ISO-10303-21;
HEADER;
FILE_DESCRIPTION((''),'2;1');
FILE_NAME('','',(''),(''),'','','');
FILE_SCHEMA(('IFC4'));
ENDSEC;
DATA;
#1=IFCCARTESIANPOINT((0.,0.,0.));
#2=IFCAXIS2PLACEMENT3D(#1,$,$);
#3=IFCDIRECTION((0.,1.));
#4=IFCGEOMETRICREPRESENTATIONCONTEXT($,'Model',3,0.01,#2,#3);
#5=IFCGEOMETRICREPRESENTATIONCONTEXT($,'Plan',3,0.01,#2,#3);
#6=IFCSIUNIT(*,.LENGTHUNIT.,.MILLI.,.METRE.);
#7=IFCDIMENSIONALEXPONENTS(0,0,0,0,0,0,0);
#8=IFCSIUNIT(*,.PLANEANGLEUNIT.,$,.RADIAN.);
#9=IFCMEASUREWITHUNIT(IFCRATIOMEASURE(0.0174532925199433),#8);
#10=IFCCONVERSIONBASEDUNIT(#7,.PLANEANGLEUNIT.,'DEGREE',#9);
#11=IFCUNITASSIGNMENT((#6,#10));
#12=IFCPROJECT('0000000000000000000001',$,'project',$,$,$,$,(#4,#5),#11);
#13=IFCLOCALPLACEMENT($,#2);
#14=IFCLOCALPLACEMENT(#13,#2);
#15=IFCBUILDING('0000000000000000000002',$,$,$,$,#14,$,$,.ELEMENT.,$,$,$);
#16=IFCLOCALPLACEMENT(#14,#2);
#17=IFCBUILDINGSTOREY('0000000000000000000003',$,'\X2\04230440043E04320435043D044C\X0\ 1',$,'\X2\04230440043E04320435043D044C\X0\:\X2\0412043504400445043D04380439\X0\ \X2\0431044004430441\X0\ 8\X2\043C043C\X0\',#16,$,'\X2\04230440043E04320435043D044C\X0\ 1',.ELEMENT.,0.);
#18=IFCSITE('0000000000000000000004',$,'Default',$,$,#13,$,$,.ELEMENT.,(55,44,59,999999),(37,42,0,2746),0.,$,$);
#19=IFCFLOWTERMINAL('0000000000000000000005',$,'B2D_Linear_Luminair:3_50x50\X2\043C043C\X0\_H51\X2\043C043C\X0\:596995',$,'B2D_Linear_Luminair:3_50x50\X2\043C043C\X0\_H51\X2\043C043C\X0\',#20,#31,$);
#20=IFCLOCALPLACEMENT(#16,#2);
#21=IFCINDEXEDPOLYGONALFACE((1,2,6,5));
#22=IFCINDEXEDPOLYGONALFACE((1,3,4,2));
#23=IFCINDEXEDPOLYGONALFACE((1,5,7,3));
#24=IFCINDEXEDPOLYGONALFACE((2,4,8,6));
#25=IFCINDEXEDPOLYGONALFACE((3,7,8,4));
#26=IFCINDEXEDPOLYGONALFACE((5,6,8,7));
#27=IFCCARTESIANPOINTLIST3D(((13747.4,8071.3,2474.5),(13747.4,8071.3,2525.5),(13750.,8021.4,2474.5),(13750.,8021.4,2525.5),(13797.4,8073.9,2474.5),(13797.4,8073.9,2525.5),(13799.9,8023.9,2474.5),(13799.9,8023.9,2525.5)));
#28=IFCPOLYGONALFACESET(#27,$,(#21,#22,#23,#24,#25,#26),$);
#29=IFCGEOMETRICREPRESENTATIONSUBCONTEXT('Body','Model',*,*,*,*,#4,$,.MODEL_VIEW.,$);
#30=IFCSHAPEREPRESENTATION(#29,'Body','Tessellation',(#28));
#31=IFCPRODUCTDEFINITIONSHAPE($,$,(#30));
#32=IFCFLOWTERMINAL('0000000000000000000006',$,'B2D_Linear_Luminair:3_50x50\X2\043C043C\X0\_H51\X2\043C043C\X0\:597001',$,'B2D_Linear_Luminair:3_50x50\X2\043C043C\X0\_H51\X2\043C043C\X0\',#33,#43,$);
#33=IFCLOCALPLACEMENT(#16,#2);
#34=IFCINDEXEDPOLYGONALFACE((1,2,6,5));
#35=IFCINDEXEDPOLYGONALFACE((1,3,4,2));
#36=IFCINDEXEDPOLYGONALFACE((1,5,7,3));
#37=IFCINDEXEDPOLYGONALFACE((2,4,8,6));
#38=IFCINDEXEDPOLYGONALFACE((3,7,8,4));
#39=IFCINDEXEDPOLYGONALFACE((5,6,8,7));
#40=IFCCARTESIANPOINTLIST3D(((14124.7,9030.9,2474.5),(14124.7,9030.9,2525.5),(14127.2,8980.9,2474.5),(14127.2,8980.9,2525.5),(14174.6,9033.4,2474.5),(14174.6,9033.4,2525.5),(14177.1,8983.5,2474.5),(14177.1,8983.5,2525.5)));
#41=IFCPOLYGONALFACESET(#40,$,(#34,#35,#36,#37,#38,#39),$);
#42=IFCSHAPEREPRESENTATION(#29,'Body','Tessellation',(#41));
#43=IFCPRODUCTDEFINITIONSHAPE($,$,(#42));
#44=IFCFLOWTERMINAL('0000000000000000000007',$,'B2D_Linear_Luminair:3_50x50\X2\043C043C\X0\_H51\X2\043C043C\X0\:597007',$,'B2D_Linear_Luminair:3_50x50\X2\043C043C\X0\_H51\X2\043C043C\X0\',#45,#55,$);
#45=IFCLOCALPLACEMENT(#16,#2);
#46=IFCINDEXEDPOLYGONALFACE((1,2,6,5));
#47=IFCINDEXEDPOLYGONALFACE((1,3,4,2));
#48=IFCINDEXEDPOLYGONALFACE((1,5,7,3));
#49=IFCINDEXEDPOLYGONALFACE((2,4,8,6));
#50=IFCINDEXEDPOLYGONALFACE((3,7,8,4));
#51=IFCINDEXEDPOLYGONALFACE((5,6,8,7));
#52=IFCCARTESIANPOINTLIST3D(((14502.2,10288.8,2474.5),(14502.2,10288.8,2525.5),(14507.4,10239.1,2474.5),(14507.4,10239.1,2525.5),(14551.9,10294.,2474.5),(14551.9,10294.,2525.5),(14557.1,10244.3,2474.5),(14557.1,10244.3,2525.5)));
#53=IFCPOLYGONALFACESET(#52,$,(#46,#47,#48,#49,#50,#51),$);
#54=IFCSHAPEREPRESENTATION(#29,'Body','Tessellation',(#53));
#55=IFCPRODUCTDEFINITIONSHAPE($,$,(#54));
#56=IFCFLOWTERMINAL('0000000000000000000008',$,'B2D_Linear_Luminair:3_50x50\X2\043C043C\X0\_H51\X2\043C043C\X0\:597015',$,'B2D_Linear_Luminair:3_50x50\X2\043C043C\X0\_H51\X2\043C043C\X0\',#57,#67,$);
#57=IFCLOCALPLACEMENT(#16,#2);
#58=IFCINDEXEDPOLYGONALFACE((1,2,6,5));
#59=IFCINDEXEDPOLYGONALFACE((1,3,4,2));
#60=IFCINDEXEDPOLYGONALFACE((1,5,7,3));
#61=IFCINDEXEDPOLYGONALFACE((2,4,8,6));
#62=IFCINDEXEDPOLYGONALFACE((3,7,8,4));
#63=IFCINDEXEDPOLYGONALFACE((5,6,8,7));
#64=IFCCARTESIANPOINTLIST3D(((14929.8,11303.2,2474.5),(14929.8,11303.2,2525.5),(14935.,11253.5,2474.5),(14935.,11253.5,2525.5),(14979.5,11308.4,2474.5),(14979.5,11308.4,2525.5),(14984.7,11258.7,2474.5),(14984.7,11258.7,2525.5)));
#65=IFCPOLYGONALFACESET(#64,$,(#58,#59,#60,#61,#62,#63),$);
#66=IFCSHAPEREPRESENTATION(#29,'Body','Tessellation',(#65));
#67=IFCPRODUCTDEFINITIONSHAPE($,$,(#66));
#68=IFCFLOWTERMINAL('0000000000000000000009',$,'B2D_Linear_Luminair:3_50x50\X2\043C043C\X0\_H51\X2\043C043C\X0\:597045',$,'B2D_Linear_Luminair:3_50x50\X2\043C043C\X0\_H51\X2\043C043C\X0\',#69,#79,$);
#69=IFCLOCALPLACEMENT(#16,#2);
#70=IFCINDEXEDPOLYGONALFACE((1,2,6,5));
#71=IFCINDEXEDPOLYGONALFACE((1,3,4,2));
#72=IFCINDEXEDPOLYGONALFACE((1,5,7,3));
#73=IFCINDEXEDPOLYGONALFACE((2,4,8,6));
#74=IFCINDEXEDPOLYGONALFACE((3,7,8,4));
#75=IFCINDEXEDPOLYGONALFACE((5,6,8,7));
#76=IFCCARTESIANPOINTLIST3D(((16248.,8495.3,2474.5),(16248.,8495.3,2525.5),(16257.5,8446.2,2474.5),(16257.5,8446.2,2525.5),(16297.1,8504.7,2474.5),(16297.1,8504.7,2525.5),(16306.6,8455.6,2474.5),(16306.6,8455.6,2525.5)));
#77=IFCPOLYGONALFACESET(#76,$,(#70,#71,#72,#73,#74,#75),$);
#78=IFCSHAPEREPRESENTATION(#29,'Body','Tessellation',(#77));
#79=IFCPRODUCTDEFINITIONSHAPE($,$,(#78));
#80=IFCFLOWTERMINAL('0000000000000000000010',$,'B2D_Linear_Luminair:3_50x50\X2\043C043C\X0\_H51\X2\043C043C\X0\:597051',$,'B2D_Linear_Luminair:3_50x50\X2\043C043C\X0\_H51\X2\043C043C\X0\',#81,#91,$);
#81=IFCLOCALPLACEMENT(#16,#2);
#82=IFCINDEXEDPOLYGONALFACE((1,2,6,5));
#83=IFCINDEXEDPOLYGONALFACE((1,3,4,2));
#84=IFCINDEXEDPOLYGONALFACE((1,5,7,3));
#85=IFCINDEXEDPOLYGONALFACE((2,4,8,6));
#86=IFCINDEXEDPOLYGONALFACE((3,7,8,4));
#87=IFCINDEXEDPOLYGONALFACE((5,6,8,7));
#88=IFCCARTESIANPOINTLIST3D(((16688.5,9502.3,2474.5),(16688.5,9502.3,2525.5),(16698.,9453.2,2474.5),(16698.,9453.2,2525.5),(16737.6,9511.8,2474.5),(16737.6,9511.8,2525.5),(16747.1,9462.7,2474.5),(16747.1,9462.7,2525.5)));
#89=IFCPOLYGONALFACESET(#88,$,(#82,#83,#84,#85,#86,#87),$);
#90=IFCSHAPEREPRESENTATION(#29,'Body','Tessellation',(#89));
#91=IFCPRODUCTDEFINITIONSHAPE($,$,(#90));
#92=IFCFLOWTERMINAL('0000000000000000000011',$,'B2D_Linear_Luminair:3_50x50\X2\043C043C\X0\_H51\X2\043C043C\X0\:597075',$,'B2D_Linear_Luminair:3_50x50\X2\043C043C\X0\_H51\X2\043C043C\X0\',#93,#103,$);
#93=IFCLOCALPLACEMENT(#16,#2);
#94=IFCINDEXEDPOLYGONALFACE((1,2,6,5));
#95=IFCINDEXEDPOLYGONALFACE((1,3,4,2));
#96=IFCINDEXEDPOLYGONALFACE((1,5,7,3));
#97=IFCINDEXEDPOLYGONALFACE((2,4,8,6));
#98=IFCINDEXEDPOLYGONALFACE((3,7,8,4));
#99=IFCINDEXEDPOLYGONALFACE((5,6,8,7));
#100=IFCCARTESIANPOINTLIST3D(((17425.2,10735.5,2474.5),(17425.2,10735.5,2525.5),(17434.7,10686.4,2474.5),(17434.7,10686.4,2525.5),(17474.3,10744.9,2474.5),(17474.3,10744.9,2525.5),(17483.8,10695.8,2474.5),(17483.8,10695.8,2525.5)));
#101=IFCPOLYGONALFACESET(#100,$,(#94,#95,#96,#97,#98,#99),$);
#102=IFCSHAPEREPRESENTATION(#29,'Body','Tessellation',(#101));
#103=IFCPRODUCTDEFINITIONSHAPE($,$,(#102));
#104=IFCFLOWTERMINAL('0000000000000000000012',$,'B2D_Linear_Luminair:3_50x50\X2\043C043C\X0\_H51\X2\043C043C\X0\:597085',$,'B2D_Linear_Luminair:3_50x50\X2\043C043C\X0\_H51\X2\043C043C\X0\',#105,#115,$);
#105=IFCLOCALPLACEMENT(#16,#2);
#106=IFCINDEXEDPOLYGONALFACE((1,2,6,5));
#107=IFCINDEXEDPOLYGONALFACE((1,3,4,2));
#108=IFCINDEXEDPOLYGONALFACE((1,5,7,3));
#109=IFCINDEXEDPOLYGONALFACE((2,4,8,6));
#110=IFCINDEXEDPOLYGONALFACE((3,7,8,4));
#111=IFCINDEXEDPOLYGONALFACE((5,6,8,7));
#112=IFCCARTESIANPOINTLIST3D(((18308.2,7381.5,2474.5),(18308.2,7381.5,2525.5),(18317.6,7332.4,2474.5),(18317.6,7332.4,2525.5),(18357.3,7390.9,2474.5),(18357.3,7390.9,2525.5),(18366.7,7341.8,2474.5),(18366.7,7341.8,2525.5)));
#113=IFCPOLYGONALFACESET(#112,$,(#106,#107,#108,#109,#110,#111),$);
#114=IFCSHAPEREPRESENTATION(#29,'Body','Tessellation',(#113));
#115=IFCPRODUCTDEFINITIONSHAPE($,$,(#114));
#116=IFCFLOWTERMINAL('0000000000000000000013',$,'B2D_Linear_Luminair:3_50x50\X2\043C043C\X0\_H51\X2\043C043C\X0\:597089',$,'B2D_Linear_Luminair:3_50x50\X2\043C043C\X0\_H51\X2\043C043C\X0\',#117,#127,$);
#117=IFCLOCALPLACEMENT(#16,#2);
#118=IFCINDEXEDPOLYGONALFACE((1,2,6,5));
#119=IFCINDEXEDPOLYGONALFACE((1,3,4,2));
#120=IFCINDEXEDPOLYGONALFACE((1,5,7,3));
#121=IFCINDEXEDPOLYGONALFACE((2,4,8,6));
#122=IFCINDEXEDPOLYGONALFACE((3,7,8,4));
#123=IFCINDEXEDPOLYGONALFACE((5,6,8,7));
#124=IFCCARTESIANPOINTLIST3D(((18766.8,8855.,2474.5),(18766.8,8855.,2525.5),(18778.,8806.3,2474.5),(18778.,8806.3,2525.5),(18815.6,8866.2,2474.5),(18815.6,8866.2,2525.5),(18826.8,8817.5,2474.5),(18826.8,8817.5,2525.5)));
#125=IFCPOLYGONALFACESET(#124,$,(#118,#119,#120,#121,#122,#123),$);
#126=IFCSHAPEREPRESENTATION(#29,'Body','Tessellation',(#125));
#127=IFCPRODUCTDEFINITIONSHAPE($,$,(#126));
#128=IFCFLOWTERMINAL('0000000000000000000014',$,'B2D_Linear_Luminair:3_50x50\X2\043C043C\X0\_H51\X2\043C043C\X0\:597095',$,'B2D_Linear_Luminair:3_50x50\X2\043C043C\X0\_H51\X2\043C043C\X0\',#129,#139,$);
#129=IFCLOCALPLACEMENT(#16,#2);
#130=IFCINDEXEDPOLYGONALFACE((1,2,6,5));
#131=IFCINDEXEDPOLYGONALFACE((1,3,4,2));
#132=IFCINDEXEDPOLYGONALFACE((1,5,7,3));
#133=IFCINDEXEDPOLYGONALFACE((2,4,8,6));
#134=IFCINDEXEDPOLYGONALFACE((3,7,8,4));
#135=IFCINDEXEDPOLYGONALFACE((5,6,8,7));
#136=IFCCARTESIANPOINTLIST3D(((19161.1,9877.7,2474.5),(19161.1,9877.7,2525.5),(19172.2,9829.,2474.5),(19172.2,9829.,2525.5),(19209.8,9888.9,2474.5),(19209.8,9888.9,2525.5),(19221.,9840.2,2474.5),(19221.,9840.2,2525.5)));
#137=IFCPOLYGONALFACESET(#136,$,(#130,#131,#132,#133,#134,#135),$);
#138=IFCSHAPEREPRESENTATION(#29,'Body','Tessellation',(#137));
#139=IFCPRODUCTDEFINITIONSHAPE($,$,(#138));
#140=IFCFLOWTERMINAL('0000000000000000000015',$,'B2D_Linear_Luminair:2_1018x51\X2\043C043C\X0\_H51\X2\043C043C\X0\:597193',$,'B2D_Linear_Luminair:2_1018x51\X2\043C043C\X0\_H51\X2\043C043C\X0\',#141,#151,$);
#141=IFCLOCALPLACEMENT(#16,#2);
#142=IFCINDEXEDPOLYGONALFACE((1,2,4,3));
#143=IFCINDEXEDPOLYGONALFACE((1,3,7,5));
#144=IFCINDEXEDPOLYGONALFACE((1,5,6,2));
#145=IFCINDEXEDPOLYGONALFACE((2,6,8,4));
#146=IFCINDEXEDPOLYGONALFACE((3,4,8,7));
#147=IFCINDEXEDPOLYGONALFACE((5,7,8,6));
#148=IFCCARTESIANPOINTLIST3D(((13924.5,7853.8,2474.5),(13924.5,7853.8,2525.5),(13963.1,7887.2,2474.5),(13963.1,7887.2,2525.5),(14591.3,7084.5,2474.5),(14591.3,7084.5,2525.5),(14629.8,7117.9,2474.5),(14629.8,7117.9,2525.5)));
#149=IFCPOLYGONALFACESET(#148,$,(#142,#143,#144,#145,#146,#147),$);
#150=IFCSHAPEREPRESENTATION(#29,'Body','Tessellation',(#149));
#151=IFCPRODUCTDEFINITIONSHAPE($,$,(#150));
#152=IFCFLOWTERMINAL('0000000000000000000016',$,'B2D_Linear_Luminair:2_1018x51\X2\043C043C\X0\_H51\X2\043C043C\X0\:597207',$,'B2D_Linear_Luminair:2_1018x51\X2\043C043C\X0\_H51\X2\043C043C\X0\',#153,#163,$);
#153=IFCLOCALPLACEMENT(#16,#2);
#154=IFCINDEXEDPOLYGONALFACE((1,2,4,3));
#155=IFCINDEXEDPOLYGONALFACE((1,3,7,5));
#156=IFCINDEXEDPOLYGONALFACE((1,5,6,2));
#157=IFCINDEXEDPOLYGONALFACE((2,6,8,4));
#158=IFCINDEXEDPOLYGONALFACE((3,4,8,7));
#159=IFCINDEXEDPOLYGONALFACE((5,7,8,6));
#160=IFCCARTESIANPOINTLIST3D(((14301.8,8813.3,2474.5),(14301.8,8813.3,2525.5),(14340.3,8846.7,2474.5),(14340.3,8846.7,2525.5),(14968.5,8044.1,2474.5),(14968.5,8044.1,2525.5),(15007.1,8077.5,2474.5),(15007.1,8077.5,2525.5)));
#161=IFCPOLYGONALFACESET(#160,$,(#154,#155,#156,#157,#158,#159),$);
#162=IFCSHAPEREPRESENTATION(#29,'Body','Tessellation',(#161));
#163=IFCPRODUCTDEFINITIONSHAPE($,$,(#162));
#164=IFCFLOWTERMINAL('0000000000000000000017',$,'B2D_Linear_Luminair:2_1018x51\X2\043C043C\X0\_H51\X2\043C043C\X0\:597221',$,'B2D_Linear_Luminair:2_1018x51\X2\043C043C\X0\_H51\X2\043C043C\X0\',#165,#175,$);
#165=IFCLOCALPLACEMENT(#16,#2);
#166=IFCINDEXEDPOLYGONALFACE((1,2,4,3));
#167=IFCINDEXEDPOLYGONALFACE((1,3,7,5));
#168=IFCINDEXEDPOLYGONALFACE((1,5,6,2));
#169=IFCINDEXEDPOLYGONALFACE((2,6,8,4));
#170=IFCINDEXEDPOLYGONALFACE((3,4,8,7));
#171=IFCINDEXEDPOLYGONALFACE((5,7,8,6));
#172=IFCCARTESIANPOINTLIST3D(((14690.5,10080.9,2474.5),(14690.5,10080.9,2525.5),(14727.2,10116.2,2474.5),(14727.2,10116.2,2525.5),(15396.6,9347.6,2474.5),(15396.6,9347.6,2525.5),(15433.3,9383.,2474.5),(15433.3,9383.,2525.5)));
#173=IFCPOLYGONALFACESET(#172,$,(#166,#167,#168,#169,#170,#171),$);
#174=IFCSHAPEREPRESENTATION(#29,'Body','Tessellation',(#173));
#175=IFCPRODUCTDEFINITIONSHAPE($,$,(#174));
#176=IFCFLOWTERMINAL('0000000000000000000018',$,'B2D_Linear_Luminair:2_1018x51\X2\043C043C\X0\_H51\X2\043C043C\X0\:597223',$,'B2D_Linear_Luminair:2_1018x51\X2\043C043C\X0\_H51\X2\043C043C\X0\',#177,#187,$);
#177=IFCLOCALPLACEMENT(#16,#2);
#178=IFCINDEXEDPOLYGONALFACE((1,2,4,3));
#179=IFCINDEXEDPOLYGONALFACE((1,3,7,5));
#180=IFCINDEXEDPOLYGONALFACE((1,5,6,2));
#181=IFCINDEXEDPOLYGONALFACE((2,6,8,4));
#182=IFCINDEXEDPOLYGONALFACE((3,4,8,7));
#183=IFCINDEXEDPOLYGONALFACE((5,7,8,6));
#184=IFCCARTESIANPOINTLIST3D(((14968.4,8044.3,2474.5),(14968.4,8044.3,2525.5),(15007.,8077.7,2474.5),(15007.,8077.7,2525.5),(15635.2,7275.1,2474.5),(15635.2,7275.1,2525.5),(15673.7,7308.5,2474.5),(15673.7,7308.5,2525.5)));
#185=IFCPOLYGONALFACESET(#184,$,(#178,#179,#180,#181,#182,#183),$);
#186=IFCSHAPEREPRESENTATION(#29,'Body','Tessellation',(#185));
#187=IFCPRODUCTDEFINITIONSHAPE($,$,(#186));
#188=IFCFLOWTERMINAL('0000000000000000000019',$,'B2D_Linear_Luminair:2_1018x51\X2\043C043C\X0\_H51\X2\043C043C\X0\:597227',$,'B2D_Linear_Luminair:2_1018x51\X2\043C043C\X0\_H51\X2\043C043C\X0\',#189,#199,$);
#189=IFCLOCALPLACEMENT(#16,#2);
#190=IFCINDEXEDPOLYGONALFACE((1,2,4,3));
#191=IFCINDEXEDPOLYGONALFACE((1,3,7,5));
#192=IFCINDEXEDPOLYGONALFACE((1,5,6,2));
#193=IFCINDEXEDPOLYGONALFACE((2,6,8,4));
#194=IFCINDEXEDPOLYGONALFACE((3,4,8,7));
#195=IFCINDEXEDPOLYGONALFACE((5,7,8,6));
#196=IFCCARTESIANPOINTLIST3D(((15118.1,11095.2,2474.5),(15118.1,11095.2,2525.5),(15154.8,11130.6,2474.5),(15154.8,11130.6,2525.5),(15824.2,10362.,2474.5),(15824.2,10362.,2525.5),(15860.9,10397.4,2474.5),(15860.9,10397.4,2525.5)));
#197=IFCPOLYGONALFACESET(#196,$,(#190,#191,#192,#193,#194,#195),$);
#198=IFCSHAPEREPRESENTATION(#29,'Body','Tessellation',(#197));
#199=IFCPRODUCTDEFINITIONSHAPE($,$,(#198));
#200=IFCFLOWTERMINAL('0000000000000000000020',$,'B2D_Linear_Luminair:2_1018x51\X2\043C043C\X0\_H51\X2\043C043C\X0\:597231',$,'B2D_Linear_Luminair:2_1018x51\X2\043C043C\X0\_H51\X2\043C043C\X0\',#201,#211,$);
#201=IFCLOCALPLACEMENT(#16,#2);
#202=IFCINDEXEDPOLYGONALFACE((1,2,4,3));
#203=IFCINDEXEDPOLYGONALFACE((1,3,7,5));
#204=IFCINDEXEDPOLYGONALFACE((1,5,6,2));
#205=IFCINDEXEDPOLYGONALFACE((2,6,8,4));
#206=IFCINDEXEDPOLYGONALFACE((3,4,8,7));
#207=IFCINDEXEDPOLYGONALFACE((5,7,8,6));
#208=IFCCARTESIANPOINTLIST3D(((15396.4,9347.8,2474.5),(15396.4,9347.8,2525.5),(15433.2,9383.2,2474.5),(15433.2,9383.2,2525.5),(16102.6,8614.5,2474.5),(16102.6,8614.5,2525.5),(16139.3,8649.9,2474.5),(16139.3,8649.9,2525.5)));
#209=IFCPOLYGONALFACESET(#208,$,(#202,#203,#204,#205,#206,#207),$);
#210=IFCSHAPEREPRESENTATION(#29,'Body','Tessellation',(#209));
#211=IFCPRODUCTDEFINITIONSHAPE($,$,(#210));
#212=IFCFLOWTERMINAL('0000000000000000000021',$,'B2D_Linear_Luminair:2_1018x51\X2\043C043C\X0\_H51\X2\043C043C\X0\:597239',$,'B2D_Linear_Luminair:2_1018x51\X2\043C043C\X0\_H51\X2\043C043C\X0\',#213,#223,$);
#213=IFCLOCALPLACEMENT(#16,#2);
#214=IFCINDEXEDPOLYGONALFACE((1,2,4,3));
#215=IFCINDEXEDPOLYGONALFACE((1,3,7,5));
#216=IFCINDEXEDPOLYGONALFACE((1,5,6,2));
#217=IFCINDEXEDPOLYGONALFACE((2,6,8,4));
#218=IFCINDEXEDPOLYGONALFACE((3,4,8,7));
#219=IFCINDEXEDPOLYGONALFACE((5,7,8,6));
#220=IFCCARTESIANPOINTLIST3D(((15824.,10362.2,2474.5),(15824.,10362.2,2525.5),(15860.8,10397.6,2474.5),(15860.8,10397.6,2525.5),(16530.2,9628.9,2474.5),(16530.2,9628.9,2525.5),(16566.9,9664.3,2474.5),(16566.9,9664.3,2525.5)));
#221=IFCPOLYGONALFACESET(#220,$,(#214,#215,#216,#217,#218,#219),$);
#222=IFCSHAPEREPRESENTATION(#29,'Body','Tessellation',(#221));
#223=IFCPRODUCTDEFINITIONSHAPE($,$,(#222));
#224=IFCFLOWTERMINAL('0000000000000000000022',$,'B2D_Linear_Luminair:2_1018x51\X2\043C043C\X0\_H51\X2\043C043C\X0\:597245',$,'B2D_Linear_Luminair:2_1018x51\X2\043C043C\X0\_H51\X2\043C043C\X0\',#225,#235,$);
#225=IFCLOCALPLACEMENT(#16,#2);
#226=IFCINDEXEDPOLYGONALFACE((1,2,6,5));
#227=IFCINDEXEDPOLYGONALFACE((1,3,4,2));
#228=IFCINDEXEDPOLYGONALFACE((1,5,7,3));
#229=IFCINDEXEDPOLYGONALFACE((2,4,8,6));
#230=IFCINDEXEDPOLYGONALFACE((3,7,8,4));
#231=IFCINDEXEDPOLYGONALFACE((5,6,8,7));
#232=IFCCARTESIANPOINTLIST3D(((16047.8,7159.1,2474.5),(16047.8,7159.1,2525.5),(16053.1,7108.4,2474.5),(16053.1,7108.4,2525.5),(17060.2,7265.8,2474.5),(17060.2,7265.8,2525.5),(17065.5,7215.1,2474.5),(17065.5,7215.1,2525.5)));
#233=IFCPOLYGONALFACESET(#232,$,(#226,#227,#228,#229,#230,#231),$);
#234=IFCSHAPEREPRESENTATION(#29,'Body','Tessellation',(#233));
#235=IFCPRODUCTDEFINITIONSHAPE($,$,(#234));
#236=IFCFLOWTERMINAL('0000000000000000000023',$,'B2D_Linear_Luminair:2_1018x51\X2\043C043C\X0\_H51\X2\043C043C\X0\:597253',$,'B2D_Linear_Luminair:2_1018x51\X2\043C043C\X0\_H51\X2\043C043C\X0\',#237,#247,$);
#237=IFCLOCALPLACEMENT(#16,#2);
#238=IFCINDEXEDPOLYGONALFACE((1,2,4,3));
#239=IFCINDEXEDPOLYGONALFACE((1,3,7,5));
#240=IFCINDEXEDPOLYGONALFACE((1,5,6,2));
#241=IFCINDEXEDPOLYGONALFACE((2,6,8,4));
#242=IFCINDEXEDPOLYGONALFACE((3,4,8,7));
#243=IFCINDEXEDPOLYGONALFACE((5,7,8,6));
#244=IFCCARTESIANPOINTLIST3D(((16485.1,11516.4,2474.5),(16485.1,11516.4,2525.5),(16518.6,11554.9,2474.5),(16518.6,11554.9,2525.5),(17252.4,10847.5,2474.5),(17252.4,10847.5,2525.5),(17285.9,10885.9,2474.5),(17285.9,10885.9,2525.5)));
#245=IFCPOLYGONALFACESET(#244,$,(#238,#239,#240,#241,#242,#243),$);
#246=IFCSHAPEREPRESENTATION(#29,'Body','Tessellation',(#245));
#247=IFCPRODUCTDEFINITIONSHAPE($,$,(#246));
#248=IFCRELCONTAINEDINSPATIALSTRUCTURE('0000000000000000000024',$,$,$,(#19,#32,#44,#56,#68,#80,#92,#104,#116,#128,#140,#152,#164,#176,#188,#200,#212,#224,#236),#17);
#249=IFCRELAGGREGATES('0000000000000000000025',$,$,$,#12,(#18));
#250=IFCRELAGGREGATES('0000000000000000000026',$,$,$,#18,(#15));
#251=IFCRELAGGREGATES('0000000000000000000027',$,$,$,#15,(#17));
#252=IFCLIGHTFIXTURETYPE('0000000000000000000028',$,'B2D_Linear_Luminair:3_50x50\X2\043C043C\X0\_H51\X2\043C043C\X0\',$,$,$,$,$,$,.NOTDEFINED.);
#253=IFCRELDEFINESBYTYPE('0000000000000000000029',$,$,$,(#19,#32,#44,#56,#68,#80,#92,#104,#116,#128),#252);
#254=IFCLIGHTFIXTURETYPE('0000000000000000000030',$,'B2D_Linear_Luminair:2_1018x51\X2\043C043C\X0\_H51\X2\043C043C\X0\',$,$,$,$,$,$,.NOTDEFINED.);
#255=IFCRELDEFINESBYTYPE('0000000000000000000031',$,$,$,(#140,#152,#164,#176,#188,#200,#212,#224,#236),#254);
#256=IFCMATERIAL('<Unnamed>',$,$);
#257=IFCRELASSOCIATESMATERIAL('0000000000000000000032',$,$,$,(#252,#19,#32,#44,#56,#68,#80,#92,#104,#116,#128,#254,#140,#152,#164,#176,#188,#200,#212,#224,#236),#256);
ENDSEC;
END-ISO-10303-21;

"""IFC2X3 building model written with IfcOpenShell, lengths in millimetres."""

from ifc_helpers import new_model, entity, si_unit, converted_unit, direction, frame, origin, origin_2d_with_axis, place, context, subcontext, project, spatial, rectangle, extrude, source, transform, mapped, material, type_object, type_shapes, element, save


model = new_model("IFC2X3")

# Units and contexts
model_context = context("Model", 3, precision=0.01, world=origin(), true_north=direction((0.0, 1.0)))
plan_context = context("Plan", 3, precision=0.01, world=origin(), true_north=direction((0.0, 1.0)))
body_context = subcontext(model_context, "Body", "Model", "MODEL_VIEW")
ifc_project = project(units=[si_unit("LENGTHUNIT", "METRE", prefix="MILLI"), converted_unit("PLANEANGLEUNIT", "DEGREE", entity("IfcRatioMeasure", 0.0174532925199433), si_unit("PLANEANGLEUNIT", "RADIAN"), dimensions=[0, 0, 0, 0, 0, 0, 0])], contexts=[model_context, plan_context])

# Site, building, storey
site_placement = place(None, origin())
site = spatial("IfcSite", under=ifc_project, at=site_placement, Name="Default", CompositionType="ELEMENT", RefLatitude=(55, 44, 59, 999999), RefLongitude=(37, 42, 0, 2746), RefElevation=0.0)
building_placement = place(site_placement, origin())
building = spatial("IfcBuilding", under=site, at=building_placement, CompositionType="ELEMENT")
storey_placement = place(building_placement, origin())
storey = spatial("IfcBuildingStorey", under=building, at=storey_placement, Name="Уровень 1", ObjectType="Уровень:Верхний брус 8мм", LongName="Уровень 1", CompositionType="ELEMENT", Elevation=0.0)

# Flow terminals
ifc_material = material(Name="<Unnamed>")
light_fixture_type_1 = type_object("IfcLightFixtureType", Name="B2D_Linear_Luminair:3_50x50мм_H51мм", PredefinedType="NOTDEFINED", material=ifc_material)
shared_shape_1 = source(origin(), body_context, "Body", "SweptSolid", [
    extrude(rectangle(XDim=50.0, YDim=50.0, at=origin_2d_with_axis()), frame((0.0, 0.0, 0.0), z_axis=(0.0, 0.0, 1.0), x_axis=(-1.0, 0.0, 0.0)), (0.0, 0.0, 1.0), 51.0),
])
type_shapes(light_fixture_type_1, [shared_shape_1])
for number, where, z_axis, x_axis, name in (
    (1, (13773.7, 8047.6, 2525.5), (0.0, 0.0, -1.0), (0.998702, 0.050942, 0.0), "B2D_Linear_Luminair:3_50x50мм_H51мм:596995"),
    (2, (14150.9, 9007.2, 2525.5), (0.0, 0.0, -1.0), (0.998702, 0.050942, 0.0), "B2D_Linear_Luminair:3_50x50мм_H51мм:597001"),
    (3, (14529.7, 10266.6, 2525.5), (0.0, 0.0, -1.0), (0.994667, 0.10314, 0.0), "B2D_Linear_Luminair:3_50x50мм_H51мм:597007"),
    (4, (14957.3, 11280.9, 2525.5), (0.0, 0.0, -1.0), (0.994667, 0.10314, 0.0), "B2D_Linear_Luminair:3_50x50мм_H51мм:597015"),
    (5, (16277.3, 8475.5, 2525.5), (0.0, 0.0, -1.0), (0.981893, 0.189438, 0.0), "B2D_Linear_Luminair:3_50x50мм_H51мм:597045"),
    (6, (16717.8, 9482.5, 2525.5), (0.0, 0.0, -1.0), (0.981893, 0.189438, 0.0), "B2D_Linear_Luminair:3_50x50мм_H51мм:597051"),
    (7, (17454.5, 10715.6, 2525.5), (0.0, 0.0, -1.0), (0.981893, 0.189438, 0.0), "B2D_Linear_Luminair:3_50x50мм_H51мм:597075"),
    (8, (18337.5, 7361.6, 2525.5), (0.0, 0.0, -1.0), (0.981893, 0.189438, 0.0), "B2D_Linear_Luminair:3_50x50мм_H51мм:597085"),
    (9, (18796.8, 8836.3, 2525.5), (0.0, 0.0, -1.0), (0.974683, 0.22359, 0.0), "B2D_Linear_Luminair:3_50x50мм_H51мм:597089"),
    (10, (19191.0, 9859.0, 2525.5), (0.0, 0.0, -1.0), (0.974683, 0.22359, 0.0), "B2D_Linear_Luminair:3_50x50мм_H51мм:597095"),
):
    element("IfcFlowTerminal", number, at=place(storey_placement, frame(where, z_axis=z_axis, x_axis=x_axis)), inside=storey, type_object=light_fixture_type_1, material=ifc_material, Name=name, ObjectType="B2D_Linear_Luminair:3_50x50мм_H51мм", context=body_context, shape_type="MappedRepresentation", body=[
        mapped(shared_shape_1, transform((0.0, 0.0, 0.0), scale=1.0)),
    ])
light_fixture_type_2 = type_object("IfcLightFixtureType", Name="B2D_Linear_Luminair:2_1018x51мм_H51мм", PredefinedType="NOTDEFINED", material=ifc_material)
shared_shape_2 = source(origin(), body_context, "Body", "SweptSolid", [
    extrude(rectangle(XDim=1018.0, YDim=51.0, at=origin_2d_with_axis()), frame((0.0, 0.0, 0.0), z_axis=(0.0, 0.0, 1.0), x_axis=(-1.0, 0.0, 0.0)), (0.0, 0.0, 1.0), 51.0),
])
type_shapes(light_fixture_type_2, [shared_shape_2])
for number, where, z_axis, x_axis, name in (
    (11, (14277.2, 7485.9, 2525.5), (0.0, 0.0, -1.0), (0.655005, -0.755625, 0.0), "B2D_Linear_Luminair:2_1018x51мм_H51мм:597193"),
    (12, (14654.4, 8445.4, 2525.5), (0.0, 0.0, -1.0), (0.655005, -0.755625, 0.0), "B2D_Linear_Luminair:2_1018x51мм_H51мм:597207"),
    (13, (15061.9, 9731.9, 2525.5), (0.0, 0.0, -1.0), (0.693653, -0.720309, 0.0), "B2D_Linear_Luminair:2_1018x51мм_H51мм:597221"),
    (14, (15321.1, 7676.4, 2525.5), (0.0, 0.0, -1.0), (0.655005, -0.755625, 0.0), "B2D_Linear_Luminair:2_1018x51мм_H51мм:597223"),
    (15, (15489.5, 10746.3, 2525.5), (0.0, 0.0, -1.0), (0.693653, -0.720309, 0.0), "B2D_Linear_Luminair:2_1018x51мм_H51мм:597227"),
    (16, (15767.9, 8998.9, 2525.5), (0.0, 0.0, -1.0), (0.693653, -0.720309, 0.0), "B2D_Linear_Luminair:2_1018x51мм_H51мм:597231"),
    (17, (16195.5, 10013.2, 2525.5), (0.0, 0.0, -1.0), (0.693653, -0.720309, 0.0), "B2D_Linear_Luminair:2_1018x51мм_H51мм:597239"),
    (18, (16556.6, 7187.1, 2525.5), (0.0, 0.0, -1.0), (0.994485, 0.104876, 0.0), "B2D_Linear_Luminair:2_1018x51мм_H51мм:597245"),
    (19, (16885.5, 11201.2, 2525.5), (0.0, 0.0, -1.0), (0.753793, -0.657112, 0.0), "B2D_Linear_Luminair:2_1018x51мм_H51мм:597253"),
):
    element("IfcFlowTerminal", number, at=place(storey_placement, frame(where, z_axis=z_axis, x_axis=x_axis)), inside=storey, type_object=light_fixture_type_2, material=ifc_material, Name=name, ObjectType="B2D_Linear_Luminair:2_1018x51мм_H51мм", context=body_context, shape_type="MappedRepresentation", body=[
        mapped(shared_shape_2, transform((0.0, 0.0, 0.0), scale=1.0)),
    ])

save(model, "model.ifc")
